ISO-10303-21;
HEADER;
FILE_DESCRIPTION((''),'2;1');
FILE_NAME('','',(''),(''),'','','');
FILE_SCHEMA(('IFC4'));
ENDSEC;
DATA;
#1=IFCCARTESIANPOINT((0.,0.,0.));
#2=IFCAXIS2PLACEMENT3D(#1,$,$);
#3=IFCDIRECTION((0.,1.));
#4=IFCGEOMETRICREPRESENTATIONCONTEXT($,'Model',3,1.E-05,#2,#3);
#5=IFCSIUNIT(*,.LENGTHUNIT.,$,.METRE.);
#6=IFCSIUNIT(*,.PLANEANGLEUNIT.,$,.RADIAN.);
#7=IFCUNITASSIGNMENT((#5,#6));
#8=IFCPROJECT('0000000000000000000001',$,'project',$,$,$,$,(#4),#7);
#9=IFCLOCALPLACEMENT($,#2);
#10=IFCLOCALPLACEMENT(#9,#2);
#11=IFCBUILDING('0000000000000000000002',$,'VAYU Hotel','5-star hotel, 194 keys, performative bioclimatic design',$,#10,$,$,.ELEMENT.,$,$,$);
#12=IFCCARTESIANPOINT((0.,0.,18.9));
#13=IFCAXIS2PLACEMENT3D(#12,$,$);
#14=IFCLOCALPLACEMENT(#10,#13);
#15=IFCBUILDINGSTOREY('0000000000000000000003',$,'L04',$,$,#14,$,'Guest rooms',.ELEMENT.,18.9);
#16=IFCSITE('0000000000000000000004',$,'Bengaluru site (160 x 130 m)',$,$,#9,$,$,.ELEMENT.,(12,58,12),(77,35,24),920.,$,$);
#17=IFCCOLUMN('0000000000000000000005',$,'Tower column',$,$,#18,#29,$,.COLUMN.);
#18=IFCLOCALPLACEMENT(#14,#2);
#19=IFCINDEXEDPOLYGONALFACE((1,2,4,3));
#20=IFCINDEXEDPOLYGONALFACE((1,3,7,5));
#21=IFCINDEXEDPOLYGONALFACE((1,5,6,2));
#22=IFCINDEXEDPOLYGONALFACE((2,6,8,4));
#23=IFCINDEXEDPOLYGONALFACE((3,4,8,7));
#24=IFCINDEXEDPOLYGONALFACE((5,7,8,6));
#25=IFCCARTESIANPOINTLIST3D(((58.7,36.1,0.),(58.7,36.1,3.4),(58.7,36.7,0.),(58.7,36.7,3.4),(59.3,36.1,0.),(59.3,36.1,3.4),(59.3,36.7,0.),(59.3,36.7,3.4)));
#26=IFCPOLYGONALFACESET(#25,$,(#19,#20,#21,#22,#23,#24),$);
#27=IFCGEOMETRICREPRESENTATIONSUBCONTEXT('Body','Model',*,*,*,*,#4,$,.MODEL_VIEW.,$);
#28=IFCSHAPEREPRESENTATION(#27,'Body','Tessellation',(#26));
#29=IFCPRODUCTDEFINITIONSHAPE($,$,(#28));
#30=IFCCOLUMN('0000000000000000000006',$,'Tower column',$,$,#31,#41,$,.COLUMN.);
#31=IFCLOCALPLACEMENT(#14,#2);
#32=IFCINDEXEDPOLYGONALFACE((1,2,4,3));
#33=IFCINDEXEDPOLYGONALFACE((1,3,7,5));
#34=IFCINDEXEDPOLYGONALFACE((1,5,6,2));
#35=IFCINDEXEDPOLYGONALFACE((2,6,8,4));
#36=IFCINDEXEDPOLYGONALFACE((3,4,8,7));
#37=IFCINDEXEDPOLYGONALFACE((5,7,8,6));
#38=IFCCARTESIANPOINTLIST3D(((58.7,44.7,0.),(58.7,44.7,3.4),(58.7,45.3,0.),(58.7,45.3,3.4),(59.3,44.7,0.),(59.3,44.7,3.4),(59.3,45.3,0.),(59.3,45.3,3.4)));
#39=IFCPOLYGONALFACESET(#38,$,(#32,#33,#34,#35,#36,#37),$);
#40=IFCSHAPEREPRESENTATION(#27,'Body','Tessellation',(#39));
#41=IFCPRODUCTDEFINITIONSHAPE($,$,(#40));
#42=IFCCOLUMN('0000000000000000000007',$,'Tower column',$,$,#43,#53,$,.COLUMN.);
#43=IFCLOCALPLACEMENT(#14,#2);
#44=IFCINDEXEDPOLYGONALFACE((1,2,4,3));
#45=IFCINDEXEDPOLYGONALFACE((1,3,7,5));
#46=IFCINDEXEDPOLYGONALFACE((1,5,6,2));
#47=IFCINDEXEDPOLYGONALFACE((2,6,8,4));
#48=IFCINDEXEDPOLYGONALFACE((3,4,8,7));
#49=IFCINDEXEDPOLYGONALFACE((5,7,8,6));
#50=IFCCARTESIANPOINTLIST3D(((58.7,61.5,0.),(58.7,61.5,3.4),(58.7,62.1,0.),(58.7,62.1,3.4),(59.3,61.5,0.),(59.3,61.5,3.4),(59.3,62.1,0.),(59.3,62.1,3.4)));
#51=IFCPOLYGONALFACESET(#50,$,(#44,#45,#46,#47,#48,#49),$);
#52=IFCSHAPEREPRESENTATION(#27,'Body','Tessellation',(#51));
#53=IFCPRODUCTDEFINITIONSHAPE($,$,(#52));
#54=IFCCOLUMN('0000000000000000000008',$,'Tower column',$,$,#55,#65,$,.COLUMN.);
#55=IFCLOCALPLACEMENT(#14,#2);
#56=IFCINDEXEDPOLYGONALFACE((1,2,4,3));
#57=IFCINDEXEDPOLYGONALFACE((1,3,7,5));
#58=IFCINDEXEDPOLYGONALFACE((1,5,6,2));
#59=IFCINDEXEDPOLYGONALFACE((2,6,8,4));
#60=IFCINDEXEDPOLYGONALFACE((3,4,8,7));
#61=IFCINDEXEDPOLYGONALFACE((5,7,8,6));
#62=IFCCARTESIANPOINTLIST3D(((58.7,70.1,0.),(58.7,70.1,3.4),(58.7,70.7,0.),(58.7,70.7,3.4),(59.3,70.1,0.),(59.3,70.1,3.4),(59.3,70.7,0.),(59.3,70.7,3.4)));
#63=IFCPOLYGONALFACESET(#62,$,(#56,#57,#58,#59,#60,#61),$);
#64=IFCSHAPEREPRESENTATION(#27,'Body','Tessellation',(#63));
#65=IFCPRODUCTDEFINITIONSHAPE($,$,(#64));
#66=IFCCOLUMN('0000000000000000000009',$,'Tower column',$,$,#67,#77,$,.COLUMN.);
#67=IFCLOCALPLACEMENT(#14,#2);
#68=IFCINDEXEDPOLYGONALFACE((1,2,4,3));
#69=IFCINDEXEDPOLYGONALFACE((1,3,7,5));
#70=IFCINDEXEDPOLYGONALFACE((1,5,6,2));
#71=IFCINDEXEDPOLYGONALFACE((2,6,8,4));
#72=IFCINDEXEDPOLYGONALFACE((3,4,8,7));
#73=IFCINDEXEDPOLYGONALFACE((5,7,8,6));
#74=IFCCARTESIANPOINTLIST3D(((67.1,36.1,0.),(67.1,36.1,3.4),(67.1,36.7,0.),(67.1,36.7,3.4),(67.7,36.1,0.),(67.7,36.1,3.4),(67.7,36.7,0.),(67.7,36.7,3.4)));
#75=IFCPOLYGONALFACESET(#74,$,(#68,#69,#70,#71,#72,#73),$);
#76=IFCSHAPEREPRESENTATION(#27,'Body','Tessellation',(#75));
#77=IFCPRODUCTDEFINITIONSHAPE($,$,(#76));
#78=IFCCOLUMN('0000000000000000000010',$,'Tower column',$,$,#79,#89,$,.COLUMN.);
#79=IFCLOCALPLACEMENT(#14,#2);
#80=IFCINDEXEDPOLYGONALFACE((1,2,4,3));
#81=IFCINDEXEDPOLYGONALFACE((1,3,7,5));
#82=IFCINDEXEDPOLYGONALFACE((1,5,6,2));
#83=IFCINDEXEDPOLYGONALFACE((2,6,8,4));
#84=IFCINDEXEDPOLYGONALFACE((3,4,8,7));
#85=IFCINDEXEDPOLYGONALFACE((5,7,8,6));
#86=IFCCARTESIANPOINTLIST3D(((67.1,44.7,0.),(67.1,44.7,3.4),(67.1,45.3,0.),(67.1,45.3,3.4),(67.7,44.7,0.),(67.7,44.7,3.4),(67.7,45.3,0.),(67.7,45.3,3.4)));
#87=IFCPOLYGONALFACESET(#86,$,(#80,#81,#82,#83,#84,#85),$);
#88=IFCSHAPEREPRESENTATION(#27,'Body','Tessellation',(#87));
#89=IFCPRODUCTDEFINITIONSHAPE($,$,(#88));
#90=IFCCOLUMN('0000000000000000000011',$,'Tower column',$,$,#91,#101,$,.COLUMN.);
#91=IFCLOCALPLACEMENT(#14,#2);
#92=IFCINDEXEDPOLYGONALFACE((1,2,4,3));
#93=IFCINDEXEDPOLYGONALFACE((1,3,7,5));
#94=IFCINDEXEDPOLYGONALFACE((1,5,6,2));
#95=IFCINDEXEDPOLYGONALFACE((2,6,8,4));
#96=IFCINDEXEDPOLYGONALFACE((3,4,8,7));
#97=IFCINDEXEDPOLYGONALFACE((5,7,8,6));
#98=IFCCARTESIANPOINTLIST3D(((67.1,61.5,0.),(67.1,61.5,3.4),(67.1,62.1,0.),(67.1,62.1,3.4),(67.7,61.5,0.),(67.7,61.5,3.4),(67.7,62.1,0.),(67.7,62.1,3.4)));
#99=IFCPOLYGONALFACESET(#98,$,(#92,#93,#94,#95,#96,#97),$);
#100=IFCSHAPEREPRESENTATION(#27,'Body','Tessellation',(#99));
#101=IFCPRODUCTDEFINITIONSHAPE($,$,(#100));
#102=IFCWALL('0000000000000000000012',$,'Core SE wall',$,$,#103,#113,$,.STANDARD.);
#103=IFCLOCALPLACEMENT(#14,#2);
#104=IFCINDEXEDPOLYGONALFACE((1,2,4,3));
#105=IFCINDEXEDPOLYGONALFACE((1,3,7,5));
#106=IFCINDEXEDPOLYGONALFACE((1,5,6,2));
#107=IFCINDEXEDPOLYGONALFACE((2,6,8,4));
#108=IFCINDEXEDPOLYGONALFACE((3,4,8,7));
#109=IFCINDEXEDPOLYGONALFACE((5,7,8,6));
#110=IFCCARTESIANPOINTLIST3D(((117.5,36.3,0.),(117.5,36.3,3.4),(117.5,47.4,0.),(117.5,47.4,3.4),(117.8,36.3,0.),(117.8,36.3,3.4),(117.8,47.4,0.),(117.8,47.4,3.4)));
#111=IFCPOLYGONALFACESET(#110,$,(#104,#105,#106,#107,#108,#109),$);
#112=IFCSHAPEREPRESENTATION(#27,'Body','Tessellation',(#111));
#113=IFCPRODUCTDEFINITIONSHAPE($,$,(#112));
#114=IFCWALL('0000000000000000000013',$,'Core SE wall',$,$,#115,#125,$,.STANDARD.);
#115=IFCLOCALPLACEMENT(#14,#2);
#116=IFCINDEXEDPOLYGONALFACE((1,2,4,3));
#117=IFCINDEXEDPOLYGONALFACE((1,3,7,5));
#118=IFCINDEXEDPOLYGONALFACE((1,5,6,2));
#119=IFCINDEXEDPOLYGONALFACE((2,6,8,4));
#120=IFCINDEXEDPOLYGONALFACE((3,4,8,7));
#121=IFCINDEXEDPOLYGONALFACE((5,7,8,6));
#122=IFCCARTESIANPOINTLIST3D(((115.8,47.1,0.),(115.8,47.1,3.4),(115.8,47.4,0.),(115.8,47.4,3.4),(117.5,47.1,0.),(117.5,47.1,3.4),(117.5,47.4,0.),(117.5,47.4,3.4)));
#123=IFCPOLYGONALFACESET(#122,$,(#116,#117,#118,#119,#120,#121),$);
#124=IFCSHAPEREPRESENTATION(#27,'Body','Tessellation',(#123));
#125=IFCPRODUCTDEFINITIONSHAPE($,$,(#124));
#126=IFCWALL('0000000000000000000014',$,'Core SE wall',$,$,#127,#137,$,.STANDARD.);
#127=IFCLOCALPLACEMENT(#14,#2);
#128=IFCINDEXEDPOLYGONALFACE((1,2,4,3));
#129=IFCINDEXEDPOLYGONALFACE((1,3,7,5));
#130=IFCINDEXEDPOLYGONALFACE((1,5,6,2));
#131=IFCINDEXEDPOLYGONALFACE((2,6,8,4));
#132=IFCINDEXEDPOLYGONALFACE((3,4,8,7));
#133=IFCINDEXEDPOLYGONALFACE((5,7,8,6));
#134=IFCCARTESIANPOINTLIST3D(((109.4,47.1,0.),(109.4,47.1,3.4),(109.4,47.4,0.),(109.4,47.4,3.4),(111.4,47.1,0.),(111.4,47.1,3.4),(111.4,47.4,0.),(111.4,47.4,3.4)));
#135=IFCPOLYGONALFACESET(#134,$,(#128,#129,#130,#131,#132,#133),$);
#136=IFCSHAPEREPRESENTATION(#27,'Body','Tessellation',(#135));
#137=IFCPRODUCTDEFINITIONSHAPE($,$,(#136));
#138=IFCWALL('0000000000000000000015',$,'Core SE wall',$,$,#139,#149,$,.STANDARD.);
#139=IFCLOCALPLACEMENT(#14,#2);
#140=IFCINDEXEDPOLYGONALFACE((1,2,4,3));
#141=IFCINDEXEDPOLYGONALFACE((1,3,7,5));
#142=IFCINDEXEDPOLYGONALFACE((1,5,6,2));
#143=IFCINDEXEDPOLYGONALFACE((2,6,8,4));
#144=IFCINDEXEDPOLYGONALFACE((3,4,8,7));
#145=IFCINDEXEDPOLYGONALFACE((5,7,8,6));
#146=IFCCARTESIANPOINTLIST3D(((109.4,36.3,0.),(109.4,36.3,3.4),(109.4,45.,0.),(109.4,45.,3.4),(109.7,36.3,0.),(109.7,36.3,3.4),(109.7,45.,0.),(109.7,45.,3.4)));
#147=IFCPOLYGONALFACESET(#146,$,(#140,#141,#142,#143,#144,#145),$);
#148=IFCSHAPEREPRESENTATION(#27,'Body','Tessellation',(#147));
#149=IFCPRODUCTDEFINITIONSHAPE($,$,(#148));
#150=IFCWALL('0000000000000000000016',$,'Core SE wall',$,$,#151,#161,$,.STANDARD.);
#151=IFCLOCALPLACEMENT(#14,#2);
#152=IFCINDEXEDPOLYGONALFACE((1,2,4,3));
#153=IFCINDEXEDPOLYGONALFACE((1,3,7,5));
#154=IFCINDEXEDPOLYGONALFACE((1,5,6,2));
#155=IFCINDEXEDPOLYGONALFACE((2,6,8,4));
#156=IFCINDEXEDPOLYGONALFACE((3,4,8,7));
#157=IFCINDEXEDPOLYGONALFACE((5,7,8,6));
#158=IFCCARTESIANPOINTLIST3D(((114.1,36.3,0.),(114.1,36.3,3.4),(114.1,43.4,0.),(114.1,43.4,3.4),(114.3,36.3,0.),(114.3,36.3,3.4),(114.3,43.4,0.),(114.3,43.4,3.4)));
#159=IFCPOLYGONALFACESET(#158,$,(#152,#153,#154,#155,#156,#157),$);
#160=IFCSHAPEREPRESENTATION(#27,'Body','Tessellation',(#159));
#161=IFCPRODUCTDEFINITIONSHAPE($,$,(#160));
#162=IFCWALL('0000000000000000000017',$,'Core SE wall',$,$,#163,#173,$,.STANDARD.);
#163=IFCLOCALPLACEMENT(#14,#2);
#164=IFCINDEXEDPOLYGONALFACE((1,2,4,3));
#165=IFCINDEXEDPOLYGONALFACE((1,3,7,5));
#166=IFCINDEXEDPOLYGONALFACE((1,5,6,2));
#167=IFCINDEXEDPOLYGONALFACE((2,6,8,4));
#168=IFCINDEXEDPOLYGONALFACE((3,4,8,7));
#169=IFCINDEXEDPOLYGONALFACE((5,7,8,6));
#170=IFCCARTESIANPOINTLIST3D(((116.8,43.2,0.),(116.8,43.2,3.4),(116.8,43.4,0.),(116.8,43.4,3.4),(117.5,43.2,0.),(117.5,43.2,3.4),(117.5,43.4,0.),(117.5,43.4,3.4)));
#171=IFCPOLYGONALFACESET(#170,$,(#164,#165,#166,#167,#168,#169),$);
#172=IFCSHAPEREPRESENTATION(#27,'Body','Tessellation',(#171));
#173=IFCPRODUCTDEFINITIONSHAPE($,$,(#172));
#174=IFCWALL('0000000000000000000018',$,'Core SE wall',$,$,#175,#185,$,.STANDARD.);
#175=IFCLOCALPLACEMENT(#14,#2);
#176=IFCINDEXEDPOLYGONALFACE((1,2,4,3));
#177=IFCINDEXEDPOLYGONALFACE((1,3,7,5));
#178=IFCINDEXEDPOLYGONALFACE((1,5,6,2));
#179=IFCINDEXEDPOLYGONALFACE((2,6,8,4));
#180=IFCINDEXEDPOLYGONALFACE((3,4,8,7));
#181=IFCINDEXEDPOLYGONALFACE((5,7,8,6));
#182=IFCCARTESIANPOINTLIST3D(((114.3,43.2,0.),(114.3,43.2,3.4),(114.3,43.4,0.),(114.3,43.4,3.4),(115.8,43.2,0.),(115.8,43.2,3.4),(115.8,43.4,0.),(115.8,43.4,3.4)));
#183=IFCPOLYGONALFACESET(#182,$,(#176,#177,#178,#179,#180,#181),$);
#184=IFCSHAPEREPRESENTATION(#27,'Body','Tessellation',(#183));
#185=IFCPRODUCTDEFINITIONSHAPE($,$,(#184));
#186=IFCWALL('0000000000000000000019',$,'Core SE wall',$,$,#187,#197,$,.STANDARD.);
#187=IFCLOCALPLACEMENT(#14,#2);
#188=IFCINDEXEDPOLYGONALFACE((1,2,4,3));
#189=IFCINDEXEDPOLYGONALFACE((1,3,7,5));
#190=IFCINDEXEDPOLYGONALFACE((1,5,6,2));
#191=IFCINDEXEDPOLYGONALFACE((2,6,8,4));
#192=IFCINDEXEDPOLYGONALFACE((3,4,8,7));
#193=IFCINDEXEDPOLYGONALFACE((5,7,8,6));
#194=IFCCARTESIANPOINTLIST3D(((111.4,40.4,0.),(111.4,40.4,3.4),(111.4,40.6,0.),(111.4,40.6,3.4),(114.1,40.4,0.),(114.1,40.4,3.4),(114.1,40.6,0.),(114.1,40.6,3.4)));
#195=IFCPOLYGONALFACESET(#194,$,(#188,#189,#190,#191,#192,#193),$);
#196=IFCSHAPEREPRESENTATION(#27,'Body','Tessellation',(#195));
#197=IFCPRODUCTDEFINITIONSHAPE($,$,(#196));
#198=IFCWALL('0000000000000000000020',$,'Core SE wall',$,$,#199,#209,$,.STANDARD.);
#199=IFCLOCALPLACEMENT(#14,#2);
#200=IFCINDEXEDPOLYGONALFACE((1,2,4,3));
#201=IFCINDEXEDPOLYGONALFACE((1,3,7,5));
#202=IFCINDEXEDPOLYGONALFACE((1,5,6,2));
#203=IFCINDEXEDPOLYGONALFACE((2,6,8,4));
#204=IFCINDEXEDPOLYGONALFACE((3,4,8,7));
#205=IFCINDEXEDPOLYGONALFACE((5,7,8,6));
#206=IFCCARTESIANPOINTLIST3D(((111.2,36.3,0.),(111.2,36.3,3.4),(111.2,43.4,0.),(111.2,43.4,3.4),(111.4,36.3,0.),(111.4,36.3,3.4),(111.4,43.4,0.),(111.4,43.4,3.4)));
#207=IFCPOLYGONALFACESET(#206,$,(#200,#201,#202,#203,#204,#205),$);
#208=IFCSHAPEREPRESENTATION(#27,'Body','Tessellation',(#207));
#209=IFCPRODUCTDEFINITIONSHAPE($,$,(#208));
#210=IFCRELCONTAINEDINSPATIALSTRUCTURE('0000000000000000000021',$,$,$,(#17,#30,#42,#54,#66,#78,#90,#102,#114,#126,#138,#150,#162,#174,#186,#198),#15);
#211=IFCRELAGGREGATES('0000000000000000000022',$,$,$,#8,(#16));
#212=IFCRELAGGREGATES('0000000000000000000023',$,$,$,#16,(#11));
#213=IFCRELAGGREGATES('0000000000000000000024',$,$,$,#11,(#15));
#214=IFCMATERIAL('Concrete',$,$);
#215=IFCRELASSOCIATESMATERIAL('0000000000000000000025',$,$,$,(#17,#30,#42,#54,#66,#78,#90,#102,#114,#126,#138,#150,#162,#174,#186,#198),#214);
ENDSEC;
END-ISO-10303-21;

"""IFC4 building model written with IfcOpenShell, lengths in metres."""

from ifc_helpers import new_model, si_unit, direction, frame, origin, place, context, subcontext, project, spatial, polyline, outline, extrude, material, element, save


model = new_model("IFC4")

# Units and contexts
model_context = context("Model", 3, precision=1e-05, world=origin(), true_north=direction((0.0, 1.0)))
body_context = subcontext(model_context, "Body", "Model", "MODEL_VIEW")
ifc_project = project(units=[si_unit("LENGTHUNIT", "METRE"), si_unit("PLANEANGLEUNIT", "RADIAN")], contexts=[model_context])

# Site, building, storey
site_placement = place(None, origin())
site = spatial("IfcSite", under=ifc_project, at=site_placement, Name="Bengaluru site (160 x 130 m)", CompositionType="ELEMENT", RefLatitude=(12, 58, 12), RefLongitude=(77, 35, 24), RefElevation=920.0)
building_placement = place(site_placement, origin())
building = spatial("IfcBuilding", under=site, at=building_placement, Name="VAYU Hotel", Description="5-star hotel, 194 keys, performative bioclimatic design", CompositionType="ELEMENT")
storey_placement = place(building_placement, frame((0.0, 0.0, 18.9)))
storey = spatial("IfcBuildingStorey", under=building, at=storey_placement, Name="L04", LongName="Guest rooms", CompositionType="ELEMENT", Elevation=18.9)

# Columns
ifc_material_1 = material(Name="Concrete")
column_1_placement = place(storey_placement, origin())
element("IfcColumn", 1, at=column_1_placement, inside=storey, material=ifc_material_1, Name="Tower column", PredefinedType="COLUMN", context=body_context, shape_type="SweptSolid", body=[
    extrude(outline(polyline([(58.7, 36.1), (59.3, 36.1), (59.3, 36.7), (58.7, 36.7), (58.7, 36.1)])), origin(), (0.0, 0.0, 1.0), 3.4),
])
column_2_placement = place(storey_placement, origin())
element("IfcColumn", 2, at=column_2_placement, inside=storey, material=ifc_material_1, Name="Tower column", PredefinedType="COLUMN", context=body_context, shape_type="SweptSolid", body=[
    extrude(outline(polyline([(58.7, 44.7), (59.3, 44.7), (59.3, 45.3), (58.7, 45.3), (58.7, 44.7)])), origin(), (0.0, 0.0, 1.0), 3.4),
])
column_3_placement = place(storey_placement, origin())
element("IfcColumn", 3, at=column_3_placement, inside=storey, material=ifc_material_1, Name="Tower column", PredefinedType="COLUMN", context=body_context, shape_type="SweptSolid", body=[
    extrude(outline(polyline([(58.7, 61.5), (59.3, 61.5), (59.3, 62.1), (58.7, 62.1), (58.7, 61.5)])), origin(), (0.0, 0.0, 1.0), 3.4),
])
column_4_placement = place(storey_placement, origin())
element("IfcColumn", 4, at=column_4_placement, inside=storey, material=ifc_material_1, Name="Tower column", PredefinedType="COLUMN", context=body_context, shape_type="SweptSolid", body=[
    extrude(outline(polyline([(58.7, 70.1), (59.3, 70.1), (59.3, 70.7), (58.7, 70.7), (58.7, 70.1)])), origin(), (0.0, 0.0, 1.0), 3.4),
])
column_5_placement = place(storey_placement, origin())
element("IfcColumn", 5, at=column_5_placement, inside=storey, material=ifc_material_1, Name="Tower column", PredefinedType="COLUMN", context=body_context, shape_type="SweptSolid", body=[
    extrude(outline(polyline([(67.1, 36.1), (67.7, 36.1), (67.7, 36.7), (67.1, 36.7), (67.1, 36.1)])), origin(), (0.0, 0.0, 1.0), 3.4),
])
column_6_placement = place(storey_placement, origin())
element("IfcColumn", 6, at=column_6_placement, inside=storey, material=ifc_material_1, Name="Tower column", PredefinedType="COLUMN", context=body_context, shape_type="SweptSolid", body=[
    extrude(outline(polyline([(67.1, 44.7), (67.7, 44.7), (67.7, 45.3), (67.1, 45.3), (67.1, 44.7)])), origin(), (0.0, 0.0, 1.0), 3.4),
])
column_7_placement = place(storey_placement, origin())
element("IfcColumn", 7, at=column_7_placement, inside=storey, material=ifc_material_1, Name="Tower column", PredefinedType="COLUMN", context=body_context, shape_type="SweptSolid", body=[
    extrude(outline(polyline([(67.1, 61.5), (67.7, 61.5), (67.7, 62.1), (67.1, 62.1), (67.1, 61.5)])), origin(), (0.0, 0.0, 1.0), 3.4),
])

# Walls
wall_1_placement = place(storey_placement, origin())
element("IfcWall", 8, at=wall_1_placement, inside=storey, material=ifc_material_1, Name="Core SE wall", PredefinedType="STANDARD", context=body_context, shape_type="SweptSolid", body=[
    extrude(outline(polyline([(117.5, 36.3), (117.5, 47.4), (117.8, 47.4), (117.8, 36.3), (117.5, 36.3)])), origin(), (0.0, 0.0, 1.0), 3.4),
])
wall_2_placement = place(storey_placement, origin())
element("IfcWall", 9, at=wall_2_placement, inside=storey, material=ifc_material_1, Name="Core SE wall", PredefinedType="STANDARD", context=body_context, shape_type="SweptSolid", body=[
    extrude(outline(polyline([(115.8, 47.4), (117.5, 47.4), (117.5, 47.1), (115.8, 47.1), (115.8, 47.4)])), origin(), (0.0, 0.0, 1.0), 3.4),
])
wall_3_placement = place(storey_placement, origin())
element("IfcWall", 10, at=wall_3_placement, inside=storey, material=ifc_material_1, Name="Core SE wall", PredefinedType="STANDARD", context=body_context, shape_type="SweptSolid", body=[
    extrude(outline(polyline([(109.4, 47.4), (111.4, 47.4), (111.4, 47.1), (109.4, 47.1), (109.4, 47.4)])), origin(), (0.0, 0.0, 1.0), 3.4),
])
wall_4_placement = place(storey_placement, origin())
element("IfcWall", 11, at=wall_4_placement, inside=storey, material=ifc_material_1, Name="Core SE wall", PredefinedType="STANDARD", context=body_context, shape_type="SweptSolid", body=[
    extrude(outline(polyline([(109.4, 36.3), (109.4, 45.0), (109.7, 45.0), (109.7, 36.3), (109.4, 36.3)])), origin(), (0.0, 0.0, 1.0), 3.4),
])
wall_5_placement = place(storey_placement, origin())
element("IfcWall", 12, at=wall_5_placement, inside=storey, material=ifc_material_1, Name="Core SE wall", PredefinedType="STANDARD", context=body_context, shape_type="SweptSolid", body=[
    extrude(outline(polyline([(114.1, 36.3), (114.1, 43.4), (114.3, 43.4), (114.3, 36.3), (114.1, 36.3)])), origin(), (0.0, 0.0, 1.0), 3.4),
])
wall_6_placement = place(storey_placement, origin())
element("IfcWall", 13, at=wall_6_placement, inside=storey, material=ifc_material_1, Name="Core SE wall", PredefinedType="STANDARD", context=body_context, shape_type="SweptSolid", body=[
    extrude(outline(polyline([(116.8, 43.4), (117.5, 43.4), (117.5, 43.2), (116.8, 43.2), (116.8, 43.4)])), origin(), (0.0, 0.0, 1.0), 3.4),
])
wall_7_placement = place(storey_placement, origin())
element("IfcWall", 14, at=wall_7_placement, inside=storey, material=ifc_material_1, Name="Core SE wall", PredefinedType="STANDARD", context=body_context, shape_type="SweptSolid", body=[
    extrude(outline(polyline([(114.3, 43.4), (115.8, 43.4), (115.8, 43.2), (114.3, 43.2), (114.3, 43.4)])), origin(), (0.0, 0.0, 1.0), 3.4),
])
wall_8_placement = place(storey_placement, origin())
element("IfcWall", 15, at=wall_8_placement, inside=storey, material=ifc_material_1, Name="Core SE wall", PredefinedType="STANDARD", context=body_context, shape_type="SweptSolid", body=[
    extrude(outline(polyline([(111.4, 40.6), (114.1, 40.6), (114.1, 40.4), (111.4, 40.4), (111.4, 40.6)])), origin(), (0.0, 0.0, 1.0), 3.4),
])
wall_9_placement = place(storey_placement, origin())
element("IfcWall", 16, at=wall_9_placement, inside=storey, material=ifc_material_1, Name="Core SE wall", PredefinedType="STANDARD", context=body_context, shape_type="SweptSolid", body=[
    extrude(outline(polyline([(111.2, 36.3), (111.2, 43.4), (111.4, 43.4), (111.4, 36.3), (111.2, 36.3)])), origin(), (0.0, 0.0, 1.0), 3.4),
])

save(model, "model.ifc")
